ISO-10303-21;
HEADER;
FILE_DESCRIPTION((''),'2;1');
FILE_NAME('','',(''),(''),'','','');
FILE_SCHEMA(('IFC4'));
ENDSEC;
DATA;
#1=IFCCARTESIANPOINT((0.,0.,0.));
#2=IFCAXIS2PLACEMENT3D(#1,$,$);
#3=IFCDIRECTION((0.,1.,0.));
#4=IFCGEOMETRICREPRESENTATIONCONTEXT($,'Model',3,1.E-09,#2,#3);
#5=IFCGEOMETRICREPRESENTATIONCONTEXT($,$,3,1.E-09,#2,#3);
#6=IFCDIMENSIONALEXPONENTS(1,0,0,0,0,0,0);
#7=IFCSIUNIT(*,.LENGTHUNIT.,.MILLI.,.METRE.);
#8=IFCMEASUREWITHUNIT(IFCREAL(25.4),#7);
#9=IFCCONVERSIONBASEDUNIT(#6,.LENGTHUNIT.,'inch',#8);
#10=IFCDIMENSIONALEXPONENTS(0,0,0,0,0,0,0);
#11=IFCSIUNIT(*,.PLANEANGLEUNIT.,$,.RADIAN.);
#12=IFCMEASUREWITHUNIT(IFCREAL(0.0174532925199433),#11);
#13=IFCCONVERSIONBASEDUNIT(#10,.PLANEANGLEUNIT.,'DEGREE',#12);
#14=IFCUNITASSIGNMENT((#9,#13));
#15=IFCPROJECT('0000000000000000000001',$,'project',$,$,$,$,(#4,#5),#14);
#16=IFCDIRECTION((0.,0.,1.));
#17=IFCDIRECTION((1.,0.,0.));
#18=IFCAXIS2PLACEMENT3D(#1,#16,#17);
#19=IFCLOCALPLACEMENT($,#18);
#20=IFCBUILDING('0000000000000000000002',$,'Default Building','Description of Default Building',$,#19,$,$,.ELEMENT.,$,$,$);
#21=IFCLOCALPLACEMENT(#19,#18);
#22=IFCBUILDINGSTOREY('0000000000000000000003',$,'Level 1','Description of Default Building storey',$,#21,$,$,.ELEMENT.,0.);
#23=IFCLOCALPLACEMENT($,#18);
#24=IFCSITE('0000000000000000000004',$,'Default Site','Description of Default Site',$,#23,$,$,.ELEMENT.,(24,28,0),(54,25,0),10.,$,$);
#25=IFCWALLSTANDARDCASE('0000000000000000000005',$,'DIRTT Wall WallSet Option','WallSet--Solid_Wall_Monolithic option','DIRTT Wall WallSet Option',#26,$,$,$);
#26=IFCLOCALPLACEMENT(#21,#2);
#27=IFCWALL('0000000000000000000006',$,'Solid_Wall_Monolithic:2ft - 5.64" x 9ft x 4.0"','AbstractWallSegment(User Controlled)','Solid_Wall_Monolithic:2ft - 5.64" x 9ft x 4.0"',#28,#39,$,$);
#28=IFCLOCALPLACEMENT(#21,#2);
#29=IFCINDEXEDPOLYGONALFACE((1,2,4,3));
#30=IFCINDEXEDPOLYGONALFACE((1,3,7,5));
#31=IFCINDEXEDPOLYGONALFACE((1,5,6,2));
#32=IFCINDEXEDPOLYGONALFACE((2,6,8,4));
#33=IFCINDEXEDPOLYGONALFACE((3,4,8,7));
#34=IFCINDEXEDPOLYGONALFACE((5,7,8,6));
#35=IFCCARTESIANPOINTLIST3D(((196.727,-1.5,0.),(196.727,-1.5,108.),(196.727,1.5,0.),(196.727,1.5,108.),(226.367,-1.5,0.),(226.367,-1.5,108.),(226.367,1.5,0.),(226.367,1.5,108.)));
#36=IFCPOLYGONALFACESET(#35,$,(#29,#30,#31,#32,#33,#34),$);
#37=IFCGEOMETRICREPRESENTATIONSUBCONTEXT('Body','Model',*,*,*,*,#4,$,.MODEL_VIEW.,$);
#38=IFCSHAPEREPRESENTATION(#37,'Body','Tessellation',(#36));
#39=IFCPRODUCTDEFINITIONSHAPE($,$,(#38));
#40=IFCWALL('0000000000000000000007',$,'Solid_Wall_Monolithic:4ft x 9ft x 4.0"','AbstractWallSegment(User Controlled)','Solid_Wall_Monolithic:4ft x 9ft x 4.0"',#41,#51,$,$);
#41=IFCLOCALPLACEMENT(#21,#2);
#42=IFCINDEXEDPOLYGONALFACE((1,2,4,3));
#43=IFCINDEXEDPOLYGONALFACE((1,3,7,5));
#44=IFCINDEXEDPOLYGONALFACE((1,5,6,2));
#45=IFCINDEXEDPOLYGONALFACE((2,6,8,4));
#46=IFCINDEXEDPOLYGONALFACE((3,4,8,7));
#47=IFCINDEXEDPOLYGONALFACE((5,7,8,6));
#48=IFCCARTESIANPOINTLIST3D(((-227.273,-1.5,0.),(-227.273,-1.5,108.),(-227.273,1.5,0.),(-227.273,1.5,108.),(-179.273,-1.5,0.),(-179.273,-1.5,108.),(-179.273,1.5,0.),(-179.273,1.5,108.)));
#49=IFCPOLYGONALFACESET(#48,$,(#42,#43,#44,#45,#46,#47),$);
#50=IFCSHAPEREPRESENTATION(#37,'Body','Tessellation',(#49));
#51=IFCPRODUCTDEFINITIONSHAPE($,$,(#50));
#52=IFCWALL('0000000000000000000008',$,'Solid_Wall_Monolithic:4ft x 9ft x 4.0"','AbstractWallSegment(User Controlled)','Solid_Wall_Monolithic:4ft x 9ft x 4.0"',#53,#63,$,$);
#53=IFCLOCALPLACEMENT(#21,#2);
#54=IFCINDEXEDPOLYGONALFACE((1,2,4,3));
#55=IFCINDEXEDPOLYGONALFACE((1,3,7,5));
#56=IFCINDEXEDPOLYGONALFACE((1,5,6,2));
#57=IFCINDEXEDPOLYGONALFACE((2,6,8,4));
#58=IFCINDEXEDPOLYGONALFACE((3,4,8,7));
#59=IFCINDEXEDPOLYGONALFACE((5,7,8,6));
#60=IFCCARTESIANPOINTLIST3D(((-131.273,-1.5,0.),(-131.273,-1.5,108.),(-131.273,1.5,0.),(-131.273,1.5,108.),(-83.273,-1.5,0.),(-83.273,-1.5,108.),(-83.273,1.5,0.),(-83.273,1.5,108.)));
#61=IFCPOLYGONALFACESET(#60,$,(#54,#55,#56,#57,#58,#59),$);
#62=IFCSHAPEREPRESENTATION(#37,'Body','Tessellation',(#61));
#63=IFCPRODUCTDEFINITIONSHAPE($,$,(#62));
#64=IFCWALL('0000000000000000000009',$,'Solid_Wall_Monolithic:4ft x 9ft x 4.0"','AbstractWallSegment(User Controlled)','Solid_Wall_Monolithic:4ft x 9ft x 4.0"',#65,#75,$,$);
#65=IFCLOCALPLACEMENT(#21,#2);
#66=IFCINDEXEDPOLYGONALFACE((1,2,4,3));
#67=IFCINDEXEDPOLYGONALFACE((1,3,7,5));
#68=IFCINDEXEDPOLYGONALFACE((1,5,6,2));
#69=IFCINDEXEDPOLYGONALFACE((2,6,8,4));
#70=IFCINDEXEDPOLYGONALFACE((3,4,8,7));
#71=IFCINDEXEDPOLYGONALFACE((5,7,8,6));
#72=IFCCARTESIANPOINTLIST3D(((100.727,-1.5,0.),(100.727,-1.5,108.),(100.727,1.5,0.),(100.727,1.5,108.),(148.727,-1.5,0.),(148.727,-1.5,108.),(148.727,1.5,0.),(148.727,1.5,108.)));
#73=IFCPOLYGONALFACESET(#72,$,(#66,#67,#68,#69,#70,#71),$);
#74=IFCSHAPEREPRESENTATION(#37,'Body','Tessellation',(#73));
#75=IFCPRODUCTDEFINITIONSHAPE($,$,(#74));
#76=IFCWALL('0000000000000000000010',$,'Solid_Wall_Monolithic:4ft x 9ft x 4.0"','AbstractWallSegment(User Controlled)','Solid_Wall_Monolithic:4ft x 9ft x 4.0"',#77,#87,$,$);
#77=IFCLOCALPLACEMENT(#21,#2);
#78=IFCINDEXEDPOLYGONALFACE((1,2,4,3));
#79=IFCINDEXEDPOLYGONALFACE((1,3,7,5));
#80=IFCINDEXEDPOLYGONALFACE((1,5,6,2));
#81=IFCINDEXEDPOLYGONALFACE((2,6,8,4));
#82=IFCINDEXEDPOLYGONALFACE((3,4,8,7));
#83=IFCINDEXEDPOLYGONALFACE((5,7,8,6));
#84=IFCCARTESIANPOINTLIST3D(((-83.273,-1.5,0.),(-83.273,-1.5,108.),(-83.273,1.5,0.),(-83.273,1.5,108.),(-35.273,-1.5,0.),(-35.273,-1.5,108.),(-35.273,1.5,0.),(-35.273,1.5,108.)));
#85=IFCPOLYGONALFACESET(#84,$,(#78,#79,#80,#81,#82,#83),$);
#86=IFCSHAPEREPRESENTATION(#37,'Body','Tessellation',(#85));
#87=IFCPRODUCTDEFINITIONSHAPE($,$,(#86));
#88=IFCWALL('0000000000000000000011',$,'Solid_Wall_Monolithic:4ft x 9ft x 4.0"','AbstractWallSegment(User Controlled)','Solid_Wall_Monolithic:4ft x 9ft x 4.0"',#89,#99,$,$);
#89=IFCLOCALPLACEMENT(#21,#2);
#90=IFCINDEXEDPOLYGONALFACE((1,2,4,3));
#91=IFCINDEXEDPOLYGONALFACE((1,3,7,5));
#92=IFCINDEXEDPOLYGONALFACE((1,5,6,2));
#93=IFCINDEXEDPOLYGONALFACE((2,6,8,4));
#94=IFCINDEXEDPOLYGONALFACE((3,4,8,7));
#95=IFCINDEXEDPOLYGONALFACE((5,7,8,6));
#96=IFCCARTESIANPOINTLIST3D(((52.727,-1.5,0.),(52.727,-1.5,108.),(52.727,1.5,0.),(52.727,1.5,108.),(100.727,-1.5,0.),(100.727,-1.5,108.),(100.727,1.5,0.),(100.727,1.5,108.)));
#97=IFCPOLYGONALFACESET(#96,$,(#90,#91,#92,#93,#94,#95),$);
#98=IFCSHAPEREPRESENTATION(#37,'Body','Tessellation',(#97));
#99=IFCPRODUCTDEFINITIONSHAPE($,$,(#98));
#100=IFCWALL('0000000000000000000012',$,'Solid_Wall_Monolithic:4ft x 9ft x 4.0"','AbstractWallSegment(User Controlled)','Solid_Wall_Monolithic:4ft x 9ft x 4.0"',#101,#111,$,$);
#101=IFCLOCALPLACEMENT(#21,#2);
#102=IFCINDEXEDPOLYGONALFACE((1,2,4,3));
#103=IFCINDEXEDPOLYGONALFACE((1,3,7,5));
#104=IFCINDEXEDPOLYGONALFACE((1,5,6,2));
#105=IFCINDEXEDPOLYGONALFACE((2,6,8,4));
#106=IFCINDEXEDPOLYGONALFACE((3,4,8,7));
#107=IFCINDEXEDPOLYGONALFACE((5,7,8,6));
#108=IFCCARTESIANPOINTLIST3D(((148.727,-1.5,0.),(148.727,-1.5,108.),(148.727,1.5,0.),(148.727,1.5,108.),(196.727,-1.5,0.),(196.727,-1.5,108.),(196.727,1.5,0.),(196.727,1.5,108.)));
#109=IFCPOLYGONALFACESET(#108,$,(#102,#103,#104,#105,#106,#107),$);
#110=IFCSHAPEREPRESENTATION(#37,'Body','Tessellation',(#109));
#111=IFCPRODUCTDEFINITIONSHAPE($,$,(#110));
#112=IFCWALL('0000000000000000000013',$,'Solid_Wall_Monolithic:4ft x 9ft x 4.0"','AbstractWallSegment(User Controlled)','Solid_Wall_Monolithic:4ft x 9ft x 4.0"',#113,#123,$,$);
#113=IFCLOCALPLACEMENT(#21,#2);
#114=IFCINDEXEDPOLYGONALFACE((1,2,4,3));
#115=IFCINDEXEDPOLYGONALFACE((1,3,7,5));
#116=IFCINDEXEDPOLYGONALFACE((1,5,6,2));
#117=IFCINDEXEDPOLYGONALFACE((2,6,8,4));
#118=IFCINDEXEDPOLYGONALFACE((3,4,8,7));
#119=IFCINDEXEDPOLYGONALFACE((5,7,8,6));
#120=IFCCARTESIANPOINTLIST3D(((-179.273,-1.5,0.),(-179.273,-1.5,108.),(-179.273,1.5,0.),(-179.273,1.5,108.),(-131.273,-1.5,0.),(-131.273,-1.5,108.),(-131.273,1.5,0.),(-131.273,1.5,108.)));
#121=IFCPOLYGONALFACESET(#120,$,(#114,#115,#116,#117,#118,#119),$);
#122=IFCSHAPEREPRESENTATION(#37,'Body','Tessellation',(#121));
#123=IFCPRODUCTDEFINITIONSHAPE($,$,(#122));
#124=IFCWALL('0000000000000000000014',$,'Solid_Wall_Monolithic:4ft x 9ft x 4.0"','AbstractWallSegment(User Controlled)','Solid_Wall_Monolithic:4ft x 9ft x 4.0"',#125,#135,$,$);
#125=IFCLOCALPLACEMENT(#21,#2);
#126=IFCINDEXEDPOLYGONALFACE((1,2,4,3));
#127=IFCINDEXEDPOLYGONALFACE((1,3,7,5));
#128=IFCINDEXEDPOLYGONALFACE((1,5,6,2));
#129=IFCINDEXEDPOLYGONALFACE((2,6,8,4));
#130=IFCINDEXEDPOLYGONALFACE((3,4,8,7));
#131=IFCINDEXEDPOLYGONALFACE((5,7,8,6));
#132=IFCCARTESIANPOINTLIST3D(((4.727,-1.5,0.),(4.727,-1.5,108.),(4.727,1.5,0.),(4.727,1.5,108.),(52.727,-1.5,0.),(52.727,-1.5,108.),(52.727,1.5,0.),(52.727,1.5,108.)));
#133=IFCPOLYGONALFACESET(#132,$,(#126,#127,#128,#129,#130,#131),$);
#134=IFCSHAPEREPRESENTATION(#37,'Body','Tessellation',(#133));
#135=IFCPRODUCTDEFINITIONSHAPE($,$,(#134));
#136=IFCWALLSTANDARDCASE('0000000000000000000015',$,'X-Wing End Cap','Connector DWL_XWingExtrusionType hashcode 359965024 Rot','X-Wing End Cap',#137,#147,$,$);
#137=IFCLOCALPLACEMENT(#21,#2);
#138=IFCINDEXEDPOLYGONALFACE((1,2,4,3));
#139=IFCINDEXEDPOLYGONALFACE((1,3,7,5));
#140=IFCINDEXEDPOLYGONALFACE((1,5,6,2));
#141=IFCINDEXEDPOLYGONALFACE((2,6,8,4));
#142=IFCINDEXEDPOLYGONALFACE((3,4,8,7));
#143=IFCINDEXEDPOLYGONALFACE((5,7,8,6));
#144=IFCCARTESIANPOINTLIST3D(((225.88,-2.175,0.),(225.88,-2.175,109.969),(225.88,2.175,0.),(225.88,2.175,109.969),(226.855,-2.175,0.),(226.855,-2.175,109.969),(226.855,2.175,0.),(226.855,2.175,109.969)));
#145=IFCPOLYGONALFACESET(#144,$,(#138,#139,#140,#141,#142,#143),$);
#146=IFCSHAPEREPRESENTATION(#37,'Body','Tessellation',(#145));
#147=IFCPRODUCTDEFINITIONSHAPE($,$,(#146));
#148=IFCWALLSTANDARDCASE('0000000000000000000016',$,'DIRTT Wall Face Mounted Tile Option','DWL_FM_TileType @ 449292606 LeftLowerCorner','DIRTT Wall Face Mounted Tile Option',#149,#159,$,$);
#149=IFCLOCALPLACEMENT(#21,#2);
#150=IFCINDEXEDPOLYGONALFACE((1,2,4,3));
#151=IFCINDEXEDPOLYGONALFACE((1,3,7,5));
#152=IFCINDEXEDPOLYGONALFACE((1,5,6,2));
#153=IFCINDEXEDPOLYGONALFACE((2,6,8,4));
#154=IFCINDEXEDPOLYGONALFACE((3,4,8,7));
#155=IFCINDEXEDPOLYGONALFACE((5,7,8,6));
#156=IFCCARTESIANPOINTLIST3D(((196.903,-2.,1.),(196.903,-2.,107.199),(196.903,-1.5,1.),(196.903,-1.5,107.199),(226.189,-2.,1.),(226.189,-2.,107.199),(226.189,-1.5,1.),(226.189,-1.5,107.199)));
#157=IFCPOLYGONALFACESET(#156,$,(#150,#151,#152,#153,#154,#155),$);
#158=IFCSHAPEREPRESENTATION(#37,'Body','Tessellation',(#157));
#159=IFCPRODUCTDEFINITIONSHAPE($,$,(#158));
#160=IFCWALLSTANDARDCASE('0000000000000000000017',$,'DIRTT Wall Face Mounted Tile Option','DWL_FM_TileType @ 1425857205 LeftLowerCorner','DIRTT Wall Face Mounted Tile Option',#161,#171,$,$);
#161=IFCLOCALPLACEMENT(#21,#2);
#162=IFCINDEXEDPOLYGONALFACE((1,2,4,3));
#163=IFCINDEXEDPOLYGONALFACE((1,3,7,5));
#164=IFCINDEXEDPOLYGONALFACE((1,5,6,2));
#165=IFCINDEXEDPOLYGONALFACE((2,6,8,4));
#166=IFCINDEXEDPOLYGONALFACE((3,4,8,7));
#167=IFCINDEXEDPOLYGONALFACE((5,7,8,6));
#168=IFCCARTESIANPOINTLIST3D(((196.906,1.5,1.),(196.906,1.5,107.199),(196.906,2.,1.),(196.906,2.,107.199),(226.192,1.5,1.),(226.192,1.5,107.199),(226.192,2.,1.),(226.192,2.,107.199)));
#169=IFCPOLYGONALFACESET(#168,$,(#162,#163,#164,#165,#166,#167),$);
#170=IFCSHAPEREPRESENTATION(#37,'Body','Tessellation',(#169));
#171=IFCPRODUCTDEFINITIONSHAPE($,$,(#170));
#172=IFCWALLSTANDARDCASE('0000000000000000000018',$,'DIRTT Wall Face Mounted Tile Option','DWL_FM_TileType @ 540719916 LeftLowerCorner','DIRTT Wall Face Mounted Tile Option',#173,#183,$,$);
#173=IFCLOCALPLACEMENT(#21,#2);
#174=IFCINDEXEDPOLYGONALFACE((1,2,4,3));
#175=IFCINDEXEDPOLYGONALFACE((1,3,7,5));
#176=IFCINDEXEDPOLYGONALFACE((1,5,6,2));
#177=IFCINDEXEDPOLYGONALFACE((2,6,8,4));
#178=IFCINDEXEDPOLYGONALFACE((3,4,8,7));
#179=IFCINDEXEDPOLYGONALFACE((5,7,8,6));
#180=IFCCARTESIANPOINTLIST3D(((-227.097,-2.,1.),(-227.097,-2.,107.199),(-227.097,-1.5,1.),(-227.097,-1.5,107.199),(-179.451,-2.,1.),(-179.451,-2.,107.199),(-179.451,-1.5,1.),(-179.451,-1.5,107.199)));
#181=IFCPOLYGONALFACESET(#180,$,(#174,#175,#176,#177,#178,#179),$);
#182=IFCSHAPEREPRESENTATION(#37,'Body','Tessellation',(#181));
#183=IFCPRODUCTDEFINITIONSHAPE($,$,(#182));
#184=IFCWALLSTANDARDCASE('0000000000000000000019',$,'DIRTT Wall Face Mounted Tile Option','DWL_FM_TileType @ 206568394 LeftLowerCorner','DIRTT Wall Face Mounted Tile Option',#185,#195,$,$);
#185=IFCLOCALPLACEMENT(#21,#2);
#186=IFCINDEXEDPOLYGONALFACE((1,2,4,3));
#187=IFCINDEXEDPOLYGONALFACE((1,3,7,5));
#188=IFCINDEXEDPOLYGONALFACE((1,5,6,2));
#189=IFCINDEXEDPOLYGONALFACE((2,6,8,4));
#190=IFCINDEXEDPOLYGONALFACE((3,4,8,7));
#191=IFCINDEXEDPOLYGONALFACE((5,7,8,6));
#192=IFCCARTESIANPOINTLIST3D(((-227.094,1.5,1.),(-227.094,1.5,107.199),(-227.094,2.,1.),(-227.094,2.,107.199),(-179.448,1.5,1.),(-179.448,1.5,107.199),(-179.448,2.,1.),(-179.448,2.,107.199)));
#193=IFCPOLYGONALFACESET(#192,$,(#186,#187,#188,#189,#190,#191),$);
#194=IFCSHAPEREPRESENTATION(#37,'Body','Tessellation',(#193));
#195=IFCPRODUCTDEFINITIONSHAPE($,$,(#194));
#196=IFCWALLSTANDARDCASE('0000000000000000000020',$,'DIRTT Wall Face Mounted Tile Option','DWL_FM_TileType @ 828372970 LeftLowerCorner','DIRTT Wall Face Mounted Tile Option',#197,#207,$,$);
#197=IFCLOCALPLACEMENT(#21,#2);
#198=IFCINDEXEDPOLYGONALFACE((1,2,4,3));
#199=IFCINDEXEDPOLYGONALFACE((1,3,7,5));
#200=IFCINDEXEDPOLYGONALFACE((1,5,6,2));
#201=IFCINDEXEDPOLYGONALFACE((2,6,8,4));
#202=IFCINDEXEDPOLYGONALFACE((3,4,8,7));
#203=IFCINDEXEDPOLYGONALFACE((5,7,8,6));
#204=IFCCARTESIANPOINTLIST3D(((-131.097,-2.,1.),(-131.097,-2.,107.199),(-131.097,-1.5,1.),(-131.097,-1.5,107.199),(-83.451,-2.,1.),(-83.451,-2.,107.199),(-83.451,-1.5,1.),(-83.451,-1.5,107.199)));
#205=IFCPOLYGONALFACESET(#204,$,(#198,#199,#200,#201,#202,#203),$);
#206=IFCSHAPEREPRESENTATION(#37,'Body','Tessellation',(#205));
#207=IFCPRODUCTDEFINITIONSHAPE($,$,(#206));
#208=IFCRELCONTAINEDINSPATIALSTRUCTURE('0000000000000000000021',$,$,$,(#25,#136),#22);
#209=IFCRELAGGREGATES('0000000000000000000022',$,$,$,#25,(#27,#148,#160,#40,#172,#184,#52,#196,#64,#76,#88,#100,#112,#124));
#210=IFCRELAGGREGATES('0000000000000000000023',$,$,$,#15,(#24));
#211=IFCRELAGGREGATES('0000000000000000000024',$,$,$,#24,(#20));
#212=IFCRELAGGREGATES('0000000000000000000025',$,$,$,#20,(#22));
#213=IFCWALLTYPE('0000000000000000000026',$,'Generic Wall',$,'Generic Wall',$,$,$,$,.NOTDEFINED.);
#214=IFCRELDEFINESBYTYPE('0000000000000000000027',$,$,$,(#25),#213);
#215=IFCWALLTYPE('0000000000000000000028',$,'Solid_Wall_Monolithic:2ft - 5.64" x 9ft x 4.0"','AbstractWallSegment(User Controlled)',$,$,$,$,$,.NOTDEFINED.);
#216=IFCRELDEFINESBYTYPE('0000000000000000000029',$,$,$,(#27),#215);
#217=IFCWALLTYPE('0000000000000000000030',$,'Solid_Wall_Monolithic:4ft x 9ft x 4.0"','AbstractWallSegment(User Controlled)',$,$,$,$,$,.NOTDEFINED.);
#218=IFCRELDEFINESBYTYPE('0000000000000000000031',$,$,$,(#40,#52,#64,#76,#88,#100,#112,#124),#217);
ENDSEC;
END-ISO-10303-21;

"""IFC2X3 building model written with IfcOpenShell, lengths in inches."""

from ifc_helpers import new_model, entity, si_unit, converted_unit, direction, frame, origin, origin_with_axes, origin_2d_with_axis, place, context, subcontext, project, spatial, rectangle, extrude, type_object, element, aggregate, save


model = new_model("IFC2X3")

# Units and contexts
model_context = context("Model", 3, precision=1e-09, world=origin(), true_north=direction((0.0, 1.0, 0.0)))
context_of_model = context(None, 3, precision=1e-09, world=origin(), true_north=direction((0.0, 1.0, 0.0)))
body_context = subcontext(model_context, "Body", "Model", "MODEL_VIEW")
ifc_project = project(units=[converted_unit("LENGTHUNIT", "inch", entity("IfcReal", 25.4), si_unit("LENGTHUNIT", "METRE", prefix="MILLI"), dimensions=[1, 0, 0, 0, 0, 0, 0]), converted_unit("PLANEANGLEUNIT", "DEGREE", entity("IfcReal", 0.0174532925199433), si_unit("PLANEANGLEUNIT", "RADIAN"), dimensions=[0, 0, 0, 0, 0, 0, 0])], contexts=[model_context, context_of_model])

# Site, building, storey
site_placement = place(None, origin_with_axes())
site = spatial("IfcSite", under=ifc_project, at=site_placement, Name="Default Site", Description="Description of Default Site", CompositionType="ELEMENT", RefLatitude=(24, 28, 0), RefLongitude=(54, 25, 0), RefElevation=10.0)
building_placement = place(None, origin_with_axes())
building = spatial("IfcBuilding", under=site, at=building_placement, Name="Default Building", Description="Description of Default Building", CompositionType="ELEMENT")
storey_placement = place(building_placement, origin_with_axes())
storey = spatial("IfcBuildingStorey", under=building, at=storey_placement, Name="Level 1", Description="Description of Default Building storey", CompositionType="ELEMENT", Elevation=0.0)

# Walls
wall_type_1 = type_object("IfcWallType", Name="Generic Wall", ApplicableOccurrence="Generic Wall", PredefinedType="NOTDEFINED")
placement_1 = place(storey_placement, origin_with_axes())
wall_1 = element("IfcWallStandardCase", 1, at=placement_1, inside=storey, type_object=wall_type_1, Name="DIRTT Wall WallSet Option", Description="WallSet--Solid_Wall_Monolithic option", ObjectType="DIRTT Wall WallSet Option")
wall_type_2 = type_object("IfcWallType", Name="Solid_Wall_Monolithic:2ft - 5.64\" x 9ft x 4.0\"", Description="AbstractWallSegment(User Controlled)", PredefinedType="NOTDEFINED")
wall_2_placement = place(placement_1, origin_with_axes())
wall_2 = element("IfcWall", 2, at=wall_2_placement, type_object=wall_type_2, Name="Solid_Wall_Monolithic:2ft - 5.64\" x 9ft x 4.0\"", Description="AbstractWallSegment(User Controlled)", ObjectType="Solid_Wall_Monolithic:2ft - 5.64\" x 9ft x 4.0\"", context=body_context, shape_type="SweptSolid", body=[
    extrude(rectangle(XDim=29.64, YDim=3.0, at=origin_2d_with_axis()), frame((211.547, 0.0, 0.0), z_axis=(0.0, 0.0, 1.0), x_axis=(1.0, 0.0, 0.0)), (0.0, 0.0, 1.0), 108.0),
])
wall_type_3 = type_object("IfcWallType", Name="Solid_Wall_Monolithic:4ft x 9ft x 4.0\"", Description="AbstractWallSegment(User Controlled)", PredefinedType="NOTDEFINED")
wall_3_placement = place(placement_1, origin_with_axes())
wall_3 = element("IfcWall", 3, at=wall_3_placement, type_object=wall_type_3, Name="Solid_Wall_Monolithic:4ft x 9ft x 4.0\"", Description="AbstractWallSegment(User Controlled)", ObjectType="Solid_Wall_Monolithic:4ft x 9ft x 4.0\"", context=body_context, shape_type="SweptSolid", body=[
    extrude(rectangle(XDim=48.0, YDim=3.0, at=origin_2d_with_axis()), frame((-203.273, 0.0, 0.0), z_axis=(0.0, 0.0, 1.0), x_axis=(1.0, 0.0, 0.0)), (0.0, 0.0, 1.0), 108.0),
])
wall_4_placement = place(placement_1, origin_with_axes())
wall_4 = element("IfcWall", 4, at=wall_4_placement, type_object=wall_type_3, Name="Solid_Wall_Monolithic:4ft x 9ft x 4.0\"", Description="AbstractWallSegment(User Controlled)", ObjectType="Solid_Wall_Monolithic:4ft x 9ft x 4.0\"", context=body_context, shape_type="SweptSolid", body=[
    extrude(rectangle(XDim=48.0, YDim=3.0, at=origin_2d_with_axis()), frame((-107.273, 0.0, 0.0), z_axis=(0.0, 0.0, 1.0), x_axis=(1.0, 0.0, 0.0)), (0.0, 0.0, 1.0), 108.0),
])
wall_5_placement = place(placement_1, origin_with_axes())
wall_5 = element("IfcWall", 5, at=wall_5_placement, type_object=wall_type_3, Name="Solid_Wall_Monolithic:4ft x 9ft x 4.0\"", Description="AbstractWallSegment(User Controlled)", ObjectType="Solid_Wall_Monolithic:4ft x 9ft x 4.0\"", context=body_context, shape_type="SweptSolid", body=[
    extrude(rectangle(XDim=48.0, YDim=3.0, at=origin_2d_with_axis()), frame((124.727, 0.0, 0.0), z_axis=(0.0, 0.0, 1.0), x_axis=(1.0, 0.0, 0.0)), (0.0, 0.0, 1.0), 108.0),
])
wall_6_placement = place(placement_1, origin_with_axes())
wall_6 = element("IfcWall", 6, at=wall_6_placement, type_object=wall_type_3, Name="Solid_Wall_Monolithic:4ft x 9ft x 4.0\"", Description="AbstractWallSegment(User Controlled)", ObjectType="Solid_Wall_Monolithic:4ft x 9ft x 4.0\"", context=body_context, shape_type="SweptSolid", body=[
    extrude(rectangle(XDim=48.0, YDim=3.0, at=origin_2d_with_axis()), frame((-59.273, 0.0, 0.0), z_axis=(0.0, 0.0, 1.0), x_axis=(1.0, 0.0, 0.0)), (0.0, 0.0, 1.0), 108.0),
])
wall_7_placement = place(placement_1, origin_with_axes())
wall_7 = element("IfcWall", 7, at=wall_7_placement, type_object=wall_type_3, Name="Solid_Wall_Monolithic:4ft x 9ft x 4.0\"", Description="AbstractWallSegment(User Controlled)", ObjectType="Solid_Wall_Monolithic:4ft x 9ft x 4.0\"", context=body_context, shape_type="SweptSolid", body=[
    extrude(rectangle(XDim=48.0, YDim=3.0, at=origin_2d_with_axis()), frame((76.727, 0.0, 0.0), z_axis=(0.0, 0.0, 1.0), x_axis=(1.0, 0.0, 0.0)), (0.0, 0.0, 1.0), 108.0),
])
wall_8_placement = place(placement_1, origin_with_axes())
wall_8 = element("IfcWall", 8, at=wall_8_placement, type_object=wall_type_3, Name="Solid_Wall_Monolithic:4ft x 9ft x 4.0\"", Description="AbstractWallSegment(User Controlled)", ObjectType="Solid_Wall_Monolithic:4ft x 9ft x 4.0\"", context=body_context, shape_type="SweptSolid", body=[
    extrude(rectangle(XDim=48.0, YDim=3.0, at=origin_2d_with_axis()), frame((172.727, 0.0, 0.0), z_axis=(0.0, 0.0, 1.0), x_axis=(1.0, 0.0, 0.0)), (0.0, 0.0, 1.0), 108.0),
])
wall_9_placement = place(placement_1, origin_with_axes())
wall_9 = element("IfcWall", 9, at=wall_9_placement, type_object=wall_type_3, Name="Solid_Wall_Monolithic:4ft x 9ft x 4.0\"", Description="AbstractWallSegment(User Controlled)", ObjectType="Solid_Wall_Monolithic:4ft x 9ft x 4.0\"", context=body_context, shape_type="SweptSolid", body=[
    extrude(rectangle(XDim=48.0, YDim=3.0, at=origin_2d_with_axis()), frame((-155.273, 0.0, 0.0), z_axis=(0.0, 0.0, 1.0), x_axis=(1.0, 0.0, 0.0)), (0.0, 0.0, 1.0), 108.0),
])
wall_10_placement = place(placement_1, origin_with_axes())
wall_10 = element("IfcWall", 10, at=wall_10_placement, type_object=wall_type_3, Name="Solid_Wall_Monolithic:4ft x 9ft x 4.0\"", Description="AbstractWallSegment(User Controlled)", ObjectType="Solid_Wall_Monolithic:4ft x 9ft x 4.0\"", context=body_context, shape_type="SweptSolid", body=[
    extrude(rectangle(XDim=48.0, YDim=3.0, at=origin_2d_with_axis()), frame((28.727, 0.0, 0.0), z_axis=(0.0, 0.0, 1.0), x_axis=(1.0, 0.0, 0.0)), (0.0, 0.0, 1.0), 108.0),
])

# Walls
element("IfcWallStandardCase", 11, at=placement_1, inside=storey, Name="X-Wing End Cap", Description="Connector DWL_XWingExtrusionType hashcode 359965024 Rot", ObjectType="X-Wing End Cap", context=body_context, shape_type="SweptSolid", body=[
    extrude(rectangle(XDim=4.35, YDim=0.975, at=origin_2d_with_axis()), frame((226.367, 0.0, 0.0), z_axis=(0.0, 0.0, 1.0), x_axis=(0.0, -1.0, 0.0)), (0.0, 0.0, 1.0), 109.969),
])
wall_11_placement = place(placement_1, origin_with_axes())
wall_11 = element("IfcWallStandardCase", 12, at=wall_11_placement, Name="DIRTT Wall Face Mounted Tile Option", Description="DWL_FM_TileType @ 449292606 LeftLowerCorner", ObjectType="DIRTT Wall Face Mounted Tile Option", context=body_context, shape_type="SweptSolid", body=[
    extrude(rectangle(XDim=29.286, YDim=0.5, at=origin_2d_with_axis()), frame((211.546, -1.75, 1.0), z_axis=(0.0, 0.0, 1.0), x_axis=(1.0, 0.0, 0.0)), (0.0, 0.0, 1.0), 106.199),
])
wall_12_placement = place(placement_1, origin_with_axes())
wall_12 = element("IfcWallStandardCase", 13, at=wall_12_placement, Name="DIRTT Wall Face Mounted Tile Option", Description="DWL_FM_TileType @ 1425857205 LeftLowerCorner", ObjectType="DIRTT Wall Face Mounted Tile Option", context=body_context, shape_type="SweptSolid", body=[
    extrude(rectangle(XDim=29.286, YDim=0.5, at=origin_2d_with_axis()), frame((211.549, 1.75, 1.0), z_axis=(0.0, 0.0, 1.0), x_axis=(-1.0, 0.0, 0.0)), (0.0, 0.0, 1.0), 106.199),
])
wall_13_placement = place(placement_1, origin_with_axes())
wall_13 = element("IfcWallStandardCase", 14, at=wall_13_placement, Name="DIRTT Wall Face Mounted Tile Option", Description="DWL_FM_TileType @ 540719916 LeftLowerCorner", ObjectType="DIRTT Wall Face Mounted Tile Option", context=body_context, shape_type="SweptSolid", body=[
    extrude(rectangle(XDim=47.646, YDim=0.5, at=origin_2d_with_axis()), frame((-203.274, -1.75, 1.0), z_axis=(0.0, 0.0, 1.0), x_axis=(1.0, 0.0, 0.0)), (0.0, 0.0, 1.0), 106.199),
])
wall_14_placement = place(placement_1, origin_with_axes())
wall_14 = element("IfcWallStandardCase", 15, at=wall_14_placement, Name="DIRTT Wall Face Mounted Tile Option", Description="DWL_FM_TileType @ 206568394 LeftLowerCorner", ObjectType="DIRTT Wall Face Mounted Tile Option", context=body_context, shape_type="SweptSolid", body=[
    extrude(rectangle(XDim=47.646, YDim=0.5, at=origin_2d_with_axis()), frame((-203.271, 1.75, 1.0), z_axis=(0.0, 0.0, 1.0), x_axis=(-1.0, 0.0, 0.0)), (0.0, 0.0, 1.0), 106.199),
])
wall_15_placement = place(placement_1, origin_with_axes())
wall_15 = element("IfcWallStandardCase", 16, at=wall_15_placement, Name="DIRTT Wall Face Mounted Tile Option", Description="DWL_FM_TileType @ 828372970 LeftLowerCorner", ObjectType="DIRTT Wall Face Mounted Tile Option", context=body_context, shape_type="SweptSolid", body=[
    extrude(rectangle(XDim=47.646, YDim=0.5, at=origin_2d_with_axis()), frame((-107.274, -1.75, 1.0), z_axis=(0.0, 0.0, 1.0), x_axis=(1.0, 0.0, 0.0)), (0.0, 0.0, 1.0), 106.199),
])

aggregate(wall_1, [wall_2, wall_11, wall_12, wall_3, wall_13, wall_14, wall_4, wall_15, wall_5, wall_6, wall_7, wall_8, wall_9, wall_10])

save(model, "model.ifc")
